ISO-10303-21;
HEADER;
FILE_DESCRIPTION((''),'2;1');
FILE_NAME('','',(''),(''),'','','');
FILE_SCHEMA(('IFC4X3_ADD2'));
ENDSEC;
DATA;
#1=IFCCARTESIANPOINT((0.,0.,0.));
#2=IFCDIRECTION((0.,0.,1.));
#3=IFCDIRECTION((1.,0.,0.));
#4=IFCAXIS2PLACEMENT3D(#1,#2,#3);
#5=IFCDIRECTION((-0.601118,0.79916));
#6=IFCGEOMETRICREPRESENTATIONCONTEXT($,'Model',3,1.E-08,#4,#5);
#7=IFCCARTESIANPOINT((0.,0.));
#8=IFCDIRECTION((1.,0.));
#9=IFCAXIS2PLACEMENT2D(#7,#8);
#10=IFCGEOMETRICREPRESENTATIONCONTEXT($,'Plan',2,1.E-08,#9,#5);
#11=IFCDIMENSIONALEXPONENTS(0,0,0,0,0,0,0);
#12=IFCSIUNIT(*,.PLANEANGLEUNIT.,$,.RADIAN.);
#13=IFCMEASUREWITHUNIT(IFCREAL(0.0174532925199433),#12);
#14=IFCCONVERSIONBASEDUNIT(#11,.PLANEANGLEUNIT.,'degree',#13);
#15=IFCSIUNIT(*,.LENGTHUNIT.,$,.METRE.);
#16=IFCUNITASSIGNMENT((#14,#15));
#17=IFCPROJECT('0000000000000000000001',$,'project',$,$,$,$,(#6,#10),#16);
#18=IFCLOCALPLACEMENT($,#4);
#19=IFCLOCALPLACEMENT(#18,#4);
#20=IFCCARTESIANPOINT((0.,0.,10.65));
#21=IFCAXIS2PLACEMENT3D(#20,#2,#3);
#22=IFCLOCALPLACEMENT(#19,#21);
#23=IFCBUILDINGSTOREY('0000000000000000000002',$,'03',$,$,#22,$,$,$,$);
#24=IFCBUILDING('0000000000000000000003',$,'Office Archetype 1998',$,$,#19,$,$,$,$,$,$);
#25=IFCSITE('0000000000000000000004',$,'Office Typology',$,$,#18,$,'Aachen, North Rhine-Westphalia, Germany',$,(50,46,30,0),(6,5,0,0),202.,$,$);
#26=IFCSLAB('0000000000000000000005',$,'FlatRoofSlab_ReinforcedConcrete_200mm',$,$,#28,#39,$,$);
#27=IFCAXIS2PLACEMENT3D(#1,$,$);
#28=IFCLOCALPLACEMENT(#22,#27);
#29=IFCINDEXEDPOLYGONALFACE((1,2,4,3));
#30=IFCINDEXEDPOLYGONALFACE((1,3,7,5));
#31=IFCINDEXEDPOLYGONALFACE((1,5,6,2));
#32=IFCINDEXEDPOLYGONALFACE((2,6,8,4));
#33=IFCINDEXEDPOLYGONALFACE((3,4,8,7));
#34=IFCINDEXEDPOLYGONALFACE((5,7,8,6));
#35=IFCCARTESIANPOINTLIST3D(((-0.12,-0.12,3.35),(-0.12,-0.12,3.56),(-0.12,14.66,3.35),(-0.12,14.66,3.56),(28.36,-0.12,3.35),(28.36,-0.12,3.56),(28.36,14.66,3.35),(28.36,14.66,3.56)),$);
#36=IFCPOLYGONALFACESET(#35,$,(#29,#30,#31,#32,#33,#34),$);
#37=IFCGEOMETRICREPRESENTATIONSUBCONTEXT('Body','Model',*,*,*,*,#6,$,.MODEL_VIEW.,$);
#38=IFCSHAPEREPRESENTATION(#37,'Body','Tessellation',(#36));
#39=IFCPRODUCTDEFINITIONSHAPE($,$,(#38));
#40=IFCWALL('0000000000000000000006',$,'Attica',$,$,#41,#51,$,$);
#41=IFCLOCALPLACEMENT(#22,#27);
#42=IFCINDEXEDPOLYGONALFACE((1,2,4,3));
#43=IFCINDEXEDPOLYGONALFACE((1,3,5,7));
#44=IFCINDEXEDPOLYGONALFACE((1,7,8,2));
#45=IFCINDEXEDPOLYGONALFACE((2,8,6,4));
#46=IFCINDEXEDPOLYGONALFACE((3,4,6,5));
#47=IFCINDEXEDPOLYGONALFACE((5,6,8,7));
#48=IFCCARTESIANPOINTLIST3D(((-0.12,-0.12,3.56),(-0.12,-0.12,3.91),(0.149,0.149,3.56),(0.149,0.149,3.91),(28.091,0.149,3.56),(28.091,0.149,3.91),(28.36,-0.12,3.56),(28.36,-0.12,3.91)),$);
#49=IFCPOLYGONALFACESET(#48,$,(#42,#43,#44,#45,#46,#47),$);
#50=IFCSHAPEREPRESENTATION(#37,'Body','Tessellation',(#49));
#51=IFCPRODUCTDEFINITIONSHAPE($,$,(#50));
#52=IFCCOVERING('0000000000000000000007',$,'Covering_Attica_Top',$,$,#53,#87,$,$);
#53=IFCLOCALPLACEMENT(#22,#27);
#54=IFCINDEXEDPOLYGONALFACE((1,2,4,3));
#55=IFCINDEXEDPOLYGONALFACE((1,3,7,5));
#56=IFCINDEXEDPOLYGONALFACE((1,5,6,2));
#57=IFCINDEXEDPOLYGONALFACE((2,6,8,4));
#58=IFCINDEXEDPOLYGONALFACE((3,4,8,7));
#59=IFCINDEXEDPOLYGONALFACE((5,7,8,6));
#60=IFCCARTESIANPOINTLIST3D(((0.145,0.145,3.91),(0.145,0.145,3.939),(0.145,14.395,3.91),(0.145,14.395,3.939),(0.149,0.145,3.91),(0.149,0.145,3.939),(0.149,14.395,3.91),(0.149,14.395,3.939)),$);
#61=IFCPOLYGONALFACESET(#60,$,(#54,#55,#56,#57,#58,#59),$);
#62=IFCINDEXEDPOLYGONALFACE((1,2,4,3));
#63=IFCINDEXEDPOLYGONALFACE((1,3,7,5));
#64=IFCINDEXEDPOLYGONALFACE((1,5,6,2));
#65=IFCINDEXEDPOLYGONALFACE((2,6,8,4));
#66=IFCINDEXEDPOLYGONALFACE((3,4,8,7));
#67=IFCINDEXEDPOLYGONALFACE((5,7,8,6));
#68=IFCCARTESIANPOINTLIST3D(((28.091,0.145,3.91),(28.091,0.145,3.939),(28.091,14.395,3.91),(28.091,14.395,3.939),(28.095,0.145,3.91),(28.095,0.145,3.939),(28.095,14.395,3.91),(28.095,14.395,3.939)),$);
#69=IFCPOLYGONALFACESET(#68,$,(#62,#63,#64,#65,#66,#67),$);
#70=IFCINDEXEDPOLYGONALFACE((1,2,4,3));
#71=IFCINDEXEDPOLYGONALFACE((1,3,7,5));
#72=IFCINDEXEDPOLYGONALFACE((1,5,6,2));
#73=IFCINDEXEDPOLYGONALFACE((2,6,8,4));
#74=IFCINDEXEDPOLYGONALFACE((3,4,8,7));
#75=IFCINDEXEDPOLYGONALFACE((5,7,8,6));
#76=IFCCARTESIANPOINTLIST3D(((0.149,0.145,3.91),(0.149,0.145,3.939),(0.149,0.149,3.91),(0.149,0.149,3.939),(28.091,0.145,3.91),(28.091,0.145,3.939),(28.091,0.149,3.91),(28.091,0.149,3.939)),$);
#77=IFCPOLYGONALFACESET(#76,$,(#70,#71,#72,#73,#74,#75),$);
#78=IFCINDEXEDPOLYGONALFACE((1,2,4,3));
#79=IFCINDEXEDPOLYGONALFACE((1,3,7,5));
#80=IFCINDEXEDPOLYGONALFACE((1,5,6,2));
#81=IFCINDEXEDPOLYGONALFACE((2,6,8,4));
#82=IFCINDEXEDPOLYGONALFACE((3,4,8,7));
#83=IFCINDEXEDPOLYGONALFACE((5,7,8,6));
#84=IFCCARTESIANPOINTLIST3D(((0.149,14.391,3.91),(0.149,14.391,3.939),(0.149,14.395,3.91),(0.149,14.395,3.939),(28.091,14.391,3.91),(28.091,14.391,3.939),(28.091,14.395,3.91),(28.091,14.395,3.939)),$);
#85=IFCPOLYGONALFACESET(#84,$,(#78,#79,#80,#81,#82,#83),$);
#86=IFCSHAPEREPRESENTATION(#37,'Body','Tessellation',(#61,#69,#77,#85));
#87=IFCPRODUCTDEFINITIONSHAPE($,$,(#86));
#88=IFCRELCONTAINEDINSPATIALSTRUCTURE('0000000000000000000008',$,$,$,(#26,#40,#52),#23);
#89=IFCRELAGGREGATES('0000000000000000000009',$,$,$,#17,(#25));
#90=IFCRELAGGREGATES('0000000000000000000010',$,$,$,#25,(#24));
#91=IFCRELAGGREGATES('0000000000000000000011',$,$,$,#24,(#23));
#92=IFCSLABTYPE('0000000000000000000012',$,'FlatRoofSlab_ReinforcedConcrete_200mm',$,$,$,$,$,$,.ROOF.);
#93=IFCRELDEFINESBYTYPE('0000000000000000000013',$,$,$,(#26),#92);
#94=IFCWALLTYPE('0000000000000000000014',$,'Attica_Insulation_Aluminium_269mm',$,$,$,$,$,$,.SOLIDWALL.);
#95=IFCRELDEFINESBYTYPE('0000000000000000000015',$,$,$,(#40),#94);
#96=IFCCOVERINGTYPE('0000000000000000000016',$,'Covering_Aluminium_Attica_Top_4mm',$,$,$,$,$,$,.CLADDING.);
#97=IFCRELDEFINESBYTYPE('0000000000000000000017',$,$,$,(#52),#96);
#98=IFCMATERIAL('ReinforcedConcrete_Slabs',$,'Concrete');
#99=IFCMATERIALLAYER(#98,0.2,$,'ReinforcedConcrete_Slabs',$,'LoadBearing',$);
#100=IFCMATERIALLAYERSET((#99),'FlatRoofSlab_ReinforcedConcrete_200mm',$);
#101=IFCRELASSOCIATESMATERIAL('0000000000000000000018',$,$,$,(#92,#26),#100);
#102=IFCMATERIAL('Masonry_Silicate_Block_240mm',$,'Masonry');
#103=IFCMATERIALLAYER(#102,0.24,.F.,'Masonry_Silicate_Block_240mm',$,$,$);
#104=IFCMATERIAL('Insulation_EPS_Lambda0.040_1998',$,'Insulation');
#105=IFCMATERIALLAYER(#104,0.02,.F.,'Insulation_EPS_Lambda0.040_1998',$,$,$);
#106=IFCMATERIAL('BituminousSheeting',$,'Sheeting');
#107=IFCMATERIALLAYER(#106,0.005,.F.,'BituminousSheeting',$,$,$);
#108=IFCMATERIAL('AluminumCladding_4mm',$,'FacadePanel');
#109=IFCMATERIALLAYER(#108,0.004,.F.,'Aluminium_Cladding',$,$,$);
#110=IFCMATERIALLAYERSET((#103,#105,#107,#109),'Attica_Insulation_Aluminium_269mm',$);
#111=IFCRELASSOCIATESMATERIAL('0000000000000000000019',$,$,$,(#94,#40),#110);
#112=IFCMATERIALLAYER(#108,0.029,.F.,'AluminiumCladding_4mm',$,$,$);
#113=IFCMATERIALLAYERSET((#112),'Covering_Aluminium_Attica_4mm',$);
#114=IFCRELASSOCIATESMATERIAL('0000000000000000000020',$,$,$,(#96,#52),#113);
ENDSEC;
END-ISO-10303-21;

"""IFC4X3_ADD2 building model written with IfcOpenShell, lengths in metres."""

from ifc_helpers import new_model, entity, si_unit, converted_unit, direction, frame, origin_with_axes, origin_2d_with_axis, place, context, subcontext, project, spatial, line, indexed_curve, outline, extrude, material, layer, layer_set, layer_usage, type_object, element, save


model = new_model("IFC4X3_ADD2")

# Units and contexts
model_context = context("Model", 3, precision=1e-08, world=origin_with_axes(), true_north=direction((-0.601118, 0.79916)))
plan_context = context("Plan", 2, precision=1e-08, world=origin_2d_with_axis(), true_north=direction((-0.601118, 0.79916)))
body_context = subcontext(model_context, "Body", "Model", "MODEL_VIEW")
ifc_project = project(units=[converted_unit("PLANEANGLEUNIT", "degree", entity("IfcReal", 0.0174532925199433), si_unit("PLANEANGLEUNIT", "RADIAN"), dimensions=[0, 0, 0, 0, 0, 0, 0]), si_unit("LENGTHUNIT", "METRE")], contexts=[model_context, plan_context])

# Site, building, storey
site_placement = place(None, origin_with_axes())
site = spatial("IfcSite", under=ifc_project, at=site_placement, Name="Office Typology", LongName="Aachen, North Rhine-Westphalia, Germany", RefLatitude=(50, 46, 30, 0), RefLongitude=(6, 5, 0, 0), RefElevation=202.0)
building_placement = place(site_placement, origin_with_axes())
building = spatial("IfcBuilding", under=site, at=building_placement, Name="Office Archetype 1998")
storey_placement = place(building_placement, frame((0.0, 0.0, 10.65), z_axis=(0.0, 0.0, 1.0), x_axis=(1.0, 0.0, 0.0)))
storey = spatial("IfcBuildingStorey", under=building, at=storey_placement, Name="03")

# Slab
ifc_material_1 = material(Name="ReinforcedConcrete_Slabs", Category="Concrete")
ifc_layer_1 = layer(ifc_material_1, 0.2, Name="ReinforcedConcrete_Slabs", Category="LoadBearing")
ifc_layer_set_1 = layer_set([ifc_layer_1], Name="FlatRoofSlab_ReinforcedConcrete_200mm")
ifc_layer_usage_1 = layer_usage(ifc_layer_set_1, "AXIS3", "POSITIVE", 0.0)
slab_type = type_object("IfcSlabType", Name="FlatRoofSlab_ReinforcedConcrete_200mm", PredefinedType="ROOF", material=ifc_layer_set_1)
slab_placement = place(storey_placement, frame((-0.12, -0.12, 3.35), z_axis=(0.0, 0.0, 1.0), x_axis=(1.0, 0.0, 0.0)))
element("IfcSlab", 1, at=slab_placement, inside=storey, type_object=slab_type, material=ifc_layer_usage_1, Name="FlatRoofSlab_ReinforcedConcrete_200mm", context=body_context, shape_type="SweptSolid", body=[
    extrude(outline(indexed_curve([(0.0, 0.0), (28.48, 0.0), (28.48, 14.78), (0.0, 14.78), (0.0, 0.0)])), None, (0.0, 0.0, 1.0), 0.21),
])

# Wall
ifc_material_2 = material(Name="Masonry_Silicate_Block_240mm", Category="Masonry")
ifc_layer_2 = layer(ifc_material_2, 0.24, ventilated=False, Name="Masonry_Silicate_Block_240mm")
ifc_material_3 = material(Name="Insulation_EPS_Lambda0.040_1998", Category="Insulation")
ifc_layer_3 = layer(ifc_material_3, 0.02, ventilated=False, Name="Insulation_EPS_Lambda0.040_1998")
ifc_material_4 = material(Name="BituminousSheeting", Category="Sheeting")
ifc_layer_4 = layer(ifc_material_4, 0.005, ventilated=False, Name="BituminousSheeting")
ifc_material_5 = material(Name="AluminumCladding_4mm", Category="FacadePanel")
ifc_layer_5 = layer(ifc_material_5, 0.004, ventilated=False, Name="Aluminium_Cladding")
ifc_layer_set_2 = layer_set([ifc_layer_2, ifc_layer_3, ifc_layer_4, ifc_layer_5], Name="Attica_Insulation_Aluminium_269mm")
ifc_layer_usage_2 = layer_usage(ifc_layer_set_2, "AXIS2", "POSITIVE", 0.0)
wall_type = type_object("IfcWallType", Name="Attica_Insulation_Aluminium_269mm", PredefinedType="SOLIDWALL", material=ifc_layer_set_2)
wall_placement = place(storey_placement, frame((-0.12, -0.12, 3.56), z_axis=(0.0, 0.0, 1.0), x_axis=(1.0, 0.0, 0.0)))
element("IfcWall", 2, at=wall_placement, inside=storey, type_object=wall_type, material=ifc_layer_usage_2, Name="Attica", context=body_context, shape_type="SweptSolid", body=[
    extrude(outline(indexed_curve([(0.0, 0.0), (0.269, 0.269), (28.211, 0.269), (28.48, 0.0)], segments=[line(1, 2, 3, 4, 1)])), origin_with_axes(), (0.0, 0.0, 1.0), 0.35),
])

# Covering
ifc_layer_6 = layer(ifc_material_5, 0.029, ventilated=False, Name="AluminiumCladding_4mm")
ifc_layer_set_3 = layer_set([ifc_layer_6], Name="Covering_Aluminium_Attica_4mm")
ifc_layer_usage_3 = layer_usage(ifc_layer_set_3, "AXIS3", "POSITIVE", 0.0)
covering_type_1 = type_object("IfcCoveringType", Name="Covering_Aluminium_Attica_Top_4mm", PredefinedType="CLADDING", material=ifc_layer_set_3)
covering_1_placement = place(storey_placement, frame((0.0, 0.0, 3.91), z_axis=(0.0, 0.0, 1.0), x_axis=(1.0, 0.0, 0.0)))
element("IfcCovering", 3, at=covering_1_placement, inside=storey, type_object=covering_type_1, material=ifc_layer_usage_3, Name="Covering_Attica_Top", context=body_context, shape_type="SweptSolid", body=[
    extrude(outline(indexed_curve([(0.145, 0.145), (0.149, 0.145), (0.149, 14.395), (0.145, 14.395), (0.145, 0.145)])), origin_with_axes(), (0.0, 0.0, 1.0), 0.029),
    extrude(outline(indexed_curve([(0.145, 0.145), (0.149, 0.145), (0.149, 14.395), (0.145, 14.395), (0.145, 0.145)])), frame((27.946, 0.0, 0.0), z_axis=(0.0, 0.0, 1.0), x_axis=(1.0, 0.0, 0.0)), (0.0, 0.0, 1.0), 0.029),
    extrude(outline(indexed_curve([(0.145, 27.797), (0.149, 27.797), (0.149, -0.145), (0.145, -0.145), (0.145, 27.797)])), frame((27.946, 0.0, 0.0), z_axis=(0.0, 0.0, 1.0), x_axis=(0.0, 1.0, 0.0)), (0.0, 0.0, 1.0), 0.029),
    extrude(outline(indexed_curve([(0.145, 27.797), (0.149, 27.797), (0.149, -0.145), (0.145, -0.145), (0.145, 27.797)])), frame((27.946, 14.246, 0.0), z_axis=(0.0, 0.0, 1.0), x_axis=(0.0, 1.0, 0.0)), (0.0, 0.0, 1.0), 0.029),
])

save(model, "model.ifc")
